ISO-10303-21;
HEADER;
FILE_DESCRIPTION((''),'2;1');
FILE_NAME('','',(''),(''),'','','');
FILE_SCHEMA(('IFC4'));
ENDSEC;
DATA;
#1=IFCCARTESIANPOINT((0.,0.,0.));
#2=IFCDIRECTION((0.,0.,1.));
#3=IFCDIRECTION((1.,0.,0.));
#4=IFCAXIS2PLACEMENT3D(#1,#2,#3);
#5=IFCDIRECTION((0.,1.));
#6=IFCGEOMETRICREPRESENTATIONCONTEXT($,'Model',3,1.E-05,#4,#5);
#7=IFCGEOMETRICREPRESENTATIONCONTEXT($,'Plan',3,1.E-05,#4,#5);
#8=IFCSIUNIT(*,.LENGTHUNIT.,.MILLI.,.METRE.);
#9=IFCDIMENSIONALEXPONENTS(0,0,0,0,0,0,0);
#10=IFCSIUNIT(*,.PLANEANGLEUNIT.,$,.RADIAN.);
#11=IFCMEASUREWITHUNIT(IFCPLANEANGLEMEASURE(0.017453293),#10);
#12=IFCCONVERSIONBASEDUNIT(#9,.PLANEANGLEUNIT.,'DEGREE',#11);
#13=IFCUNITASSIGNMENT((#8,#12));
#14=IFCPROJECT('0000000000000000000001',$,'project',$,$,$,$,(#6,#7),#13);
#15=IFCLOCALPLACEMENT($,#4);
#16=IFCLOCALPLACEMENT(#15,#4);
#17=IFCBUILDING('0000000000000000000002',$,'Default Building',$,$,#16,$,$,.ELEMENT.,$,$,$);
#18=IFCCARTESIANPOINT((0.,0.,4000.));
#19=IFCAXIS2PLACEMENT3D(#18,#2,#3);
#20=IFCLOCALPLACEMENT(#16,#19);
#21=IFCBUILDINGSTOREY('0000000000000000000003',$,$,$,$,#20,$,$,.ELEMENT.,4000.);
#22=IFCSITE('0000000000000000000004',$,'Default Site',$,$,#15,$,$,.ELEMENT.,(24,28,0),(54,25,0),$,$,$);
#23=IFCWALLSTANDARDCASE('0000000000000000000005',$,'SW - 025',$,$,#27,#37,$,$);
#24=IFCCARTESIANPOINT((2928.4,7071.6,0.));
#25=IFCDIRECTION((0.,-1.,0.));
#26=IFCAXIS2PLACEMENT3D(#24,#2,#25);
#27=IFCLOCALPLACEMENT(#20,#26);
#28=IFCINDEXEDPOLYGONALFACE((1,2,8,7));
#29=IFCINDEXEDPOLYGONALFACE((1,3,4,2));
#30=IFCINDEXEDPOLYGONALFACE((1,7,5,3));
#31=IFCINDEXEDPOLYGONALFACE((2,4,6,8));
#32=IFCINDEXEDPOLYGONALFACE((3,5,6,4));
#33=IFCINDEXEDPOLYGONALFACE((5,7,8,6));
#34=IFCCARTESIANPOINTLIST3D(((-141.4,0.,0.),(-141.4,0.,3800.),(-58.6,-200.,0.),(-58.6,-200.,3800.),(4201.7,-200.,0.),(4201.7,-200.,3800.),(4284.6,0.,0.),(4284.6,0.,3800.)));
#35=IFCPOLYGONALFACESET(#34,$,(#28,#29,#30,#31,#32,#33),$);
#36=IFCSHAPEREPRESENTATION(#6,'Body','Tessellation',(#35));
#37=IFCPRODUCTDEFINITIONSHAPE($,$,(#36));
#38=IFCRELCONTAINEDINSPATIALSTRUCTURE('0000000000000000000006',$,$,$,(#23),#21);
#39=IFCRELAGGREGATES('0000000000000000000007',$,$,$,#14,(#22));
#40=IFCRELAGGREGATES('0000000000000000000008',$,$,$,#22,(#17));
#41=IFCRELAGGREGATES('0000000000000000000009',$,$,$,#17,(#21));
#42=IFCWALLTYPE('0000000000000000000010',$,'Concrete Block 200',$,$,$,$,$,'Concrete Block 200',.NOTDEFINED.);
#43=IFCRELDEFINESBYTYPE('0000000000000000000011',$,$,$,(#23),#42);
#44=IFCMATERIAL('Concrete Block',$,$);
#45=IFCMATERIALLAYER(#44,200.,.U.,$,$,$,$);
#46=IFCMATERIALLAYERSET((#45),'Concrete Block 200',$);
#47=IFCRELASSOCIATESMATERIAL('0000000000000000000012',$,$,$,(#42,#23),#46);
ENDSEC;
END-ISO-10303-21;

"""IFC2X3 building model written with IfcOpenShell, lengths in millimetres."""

from ifc_helpers import new_model, entity, si_unit, converted_unit, direction, frame, origin_with_axes, place, context, project, spatial, polyline, outline, extrude, material, layer, layer_set, layer_usage, type_object, element, save


model = new_model("IFC2X3")

# Units and contexts
model_context = context("Model", 3, precision=1e-05, world=origin_with_axes(), true_north=direction((0.0, 1.0)))
plan_context = context("Plan", 3, precision=1e-05, world=origin_with_axes(), true_north=direction((0.0, 1.0)))
ifc_project = project(units=[si_unit("LENGTHUNIT", "METRE", prefix="MILLI"), converted_unit("PLANEANGLEUNIT", "DEGREE", entity("IfcPlaneAngleMeasure", 0.017453293), si_unit("PLANEANGLEUNIT", "RADIAN"), dimensions=[0, 0, 0, 0, 0, 0, 0])], contexts=[model_context, plan_context])

# Site, building, storey
site_placement = place(None, origin_with_axes())
site = spatial("IfcSite", under=ifc_project, at=site_placement, Name="Default Site", CompositionType="ELEMENT", RefLatitude=(24, 28, 0), RefLongitude=(54, 25, 0))
building_placement = place(site_placement, origin_with_axes())
building = spatial("IfcBuilding", under=site, at=building_placement, Name="Default Building", CompositionType="ELEMENT")
storey_placement = place(building_placement, frame((0.0, 0.0, 4000.0), z_axis=(0.0, 0.0, 1.0), x_axis=(1.0, 0.0, 0.0)))
storey = spatial("IfcBuildingStorey", under=building, at=storey_placement, CompositionType="ELEMENT", Elevation=4000.0)

# Shared definitions
ifc_material = material(Name="Concrete Block")
ifc_layer = layer(ifc_material, 200.0, ventilated="UNKNOWN")
ifc_layer_set = layer_set([ifc_layer], Name="Concrete Block 200")

# Wall
wall_type = type_object("IfcWallType", Name="Concrete Block 200", ElementType="Concrete Block 200", PredefinedType="NOTDEFINED", material=ifc_layer_set)
ifc_layer_usage_1 = layer_usage(ifc_layer_set, "AXIS2", "NEGATIVE", 0.0)
wall_1_placement = place(storey_placement, frame((2928.4, 7071.6, 0.0), z_axis=(0.0, 0.0, 1.0), x_axis=(0.0, -1.0, 0.0)))
element("IfcWallStandardCase", 1, at=wall_1_placement, inside=storey, type_object=wall_type, material=ifc_layer_usage_1, Name="SW - 025", context=model_context, shape_type="SweptSolid", body=[
    extrude(outline(polyline([(-58.6, -200.0), (4201.7, -200.0), (4284.6, 0.0), (-141.4, 0.0), (-58.6, -200.0)])), origin_with_axes(), (0.0, 0.0, 1.0), 3800.0),
])

save(model, "model.ifc")
